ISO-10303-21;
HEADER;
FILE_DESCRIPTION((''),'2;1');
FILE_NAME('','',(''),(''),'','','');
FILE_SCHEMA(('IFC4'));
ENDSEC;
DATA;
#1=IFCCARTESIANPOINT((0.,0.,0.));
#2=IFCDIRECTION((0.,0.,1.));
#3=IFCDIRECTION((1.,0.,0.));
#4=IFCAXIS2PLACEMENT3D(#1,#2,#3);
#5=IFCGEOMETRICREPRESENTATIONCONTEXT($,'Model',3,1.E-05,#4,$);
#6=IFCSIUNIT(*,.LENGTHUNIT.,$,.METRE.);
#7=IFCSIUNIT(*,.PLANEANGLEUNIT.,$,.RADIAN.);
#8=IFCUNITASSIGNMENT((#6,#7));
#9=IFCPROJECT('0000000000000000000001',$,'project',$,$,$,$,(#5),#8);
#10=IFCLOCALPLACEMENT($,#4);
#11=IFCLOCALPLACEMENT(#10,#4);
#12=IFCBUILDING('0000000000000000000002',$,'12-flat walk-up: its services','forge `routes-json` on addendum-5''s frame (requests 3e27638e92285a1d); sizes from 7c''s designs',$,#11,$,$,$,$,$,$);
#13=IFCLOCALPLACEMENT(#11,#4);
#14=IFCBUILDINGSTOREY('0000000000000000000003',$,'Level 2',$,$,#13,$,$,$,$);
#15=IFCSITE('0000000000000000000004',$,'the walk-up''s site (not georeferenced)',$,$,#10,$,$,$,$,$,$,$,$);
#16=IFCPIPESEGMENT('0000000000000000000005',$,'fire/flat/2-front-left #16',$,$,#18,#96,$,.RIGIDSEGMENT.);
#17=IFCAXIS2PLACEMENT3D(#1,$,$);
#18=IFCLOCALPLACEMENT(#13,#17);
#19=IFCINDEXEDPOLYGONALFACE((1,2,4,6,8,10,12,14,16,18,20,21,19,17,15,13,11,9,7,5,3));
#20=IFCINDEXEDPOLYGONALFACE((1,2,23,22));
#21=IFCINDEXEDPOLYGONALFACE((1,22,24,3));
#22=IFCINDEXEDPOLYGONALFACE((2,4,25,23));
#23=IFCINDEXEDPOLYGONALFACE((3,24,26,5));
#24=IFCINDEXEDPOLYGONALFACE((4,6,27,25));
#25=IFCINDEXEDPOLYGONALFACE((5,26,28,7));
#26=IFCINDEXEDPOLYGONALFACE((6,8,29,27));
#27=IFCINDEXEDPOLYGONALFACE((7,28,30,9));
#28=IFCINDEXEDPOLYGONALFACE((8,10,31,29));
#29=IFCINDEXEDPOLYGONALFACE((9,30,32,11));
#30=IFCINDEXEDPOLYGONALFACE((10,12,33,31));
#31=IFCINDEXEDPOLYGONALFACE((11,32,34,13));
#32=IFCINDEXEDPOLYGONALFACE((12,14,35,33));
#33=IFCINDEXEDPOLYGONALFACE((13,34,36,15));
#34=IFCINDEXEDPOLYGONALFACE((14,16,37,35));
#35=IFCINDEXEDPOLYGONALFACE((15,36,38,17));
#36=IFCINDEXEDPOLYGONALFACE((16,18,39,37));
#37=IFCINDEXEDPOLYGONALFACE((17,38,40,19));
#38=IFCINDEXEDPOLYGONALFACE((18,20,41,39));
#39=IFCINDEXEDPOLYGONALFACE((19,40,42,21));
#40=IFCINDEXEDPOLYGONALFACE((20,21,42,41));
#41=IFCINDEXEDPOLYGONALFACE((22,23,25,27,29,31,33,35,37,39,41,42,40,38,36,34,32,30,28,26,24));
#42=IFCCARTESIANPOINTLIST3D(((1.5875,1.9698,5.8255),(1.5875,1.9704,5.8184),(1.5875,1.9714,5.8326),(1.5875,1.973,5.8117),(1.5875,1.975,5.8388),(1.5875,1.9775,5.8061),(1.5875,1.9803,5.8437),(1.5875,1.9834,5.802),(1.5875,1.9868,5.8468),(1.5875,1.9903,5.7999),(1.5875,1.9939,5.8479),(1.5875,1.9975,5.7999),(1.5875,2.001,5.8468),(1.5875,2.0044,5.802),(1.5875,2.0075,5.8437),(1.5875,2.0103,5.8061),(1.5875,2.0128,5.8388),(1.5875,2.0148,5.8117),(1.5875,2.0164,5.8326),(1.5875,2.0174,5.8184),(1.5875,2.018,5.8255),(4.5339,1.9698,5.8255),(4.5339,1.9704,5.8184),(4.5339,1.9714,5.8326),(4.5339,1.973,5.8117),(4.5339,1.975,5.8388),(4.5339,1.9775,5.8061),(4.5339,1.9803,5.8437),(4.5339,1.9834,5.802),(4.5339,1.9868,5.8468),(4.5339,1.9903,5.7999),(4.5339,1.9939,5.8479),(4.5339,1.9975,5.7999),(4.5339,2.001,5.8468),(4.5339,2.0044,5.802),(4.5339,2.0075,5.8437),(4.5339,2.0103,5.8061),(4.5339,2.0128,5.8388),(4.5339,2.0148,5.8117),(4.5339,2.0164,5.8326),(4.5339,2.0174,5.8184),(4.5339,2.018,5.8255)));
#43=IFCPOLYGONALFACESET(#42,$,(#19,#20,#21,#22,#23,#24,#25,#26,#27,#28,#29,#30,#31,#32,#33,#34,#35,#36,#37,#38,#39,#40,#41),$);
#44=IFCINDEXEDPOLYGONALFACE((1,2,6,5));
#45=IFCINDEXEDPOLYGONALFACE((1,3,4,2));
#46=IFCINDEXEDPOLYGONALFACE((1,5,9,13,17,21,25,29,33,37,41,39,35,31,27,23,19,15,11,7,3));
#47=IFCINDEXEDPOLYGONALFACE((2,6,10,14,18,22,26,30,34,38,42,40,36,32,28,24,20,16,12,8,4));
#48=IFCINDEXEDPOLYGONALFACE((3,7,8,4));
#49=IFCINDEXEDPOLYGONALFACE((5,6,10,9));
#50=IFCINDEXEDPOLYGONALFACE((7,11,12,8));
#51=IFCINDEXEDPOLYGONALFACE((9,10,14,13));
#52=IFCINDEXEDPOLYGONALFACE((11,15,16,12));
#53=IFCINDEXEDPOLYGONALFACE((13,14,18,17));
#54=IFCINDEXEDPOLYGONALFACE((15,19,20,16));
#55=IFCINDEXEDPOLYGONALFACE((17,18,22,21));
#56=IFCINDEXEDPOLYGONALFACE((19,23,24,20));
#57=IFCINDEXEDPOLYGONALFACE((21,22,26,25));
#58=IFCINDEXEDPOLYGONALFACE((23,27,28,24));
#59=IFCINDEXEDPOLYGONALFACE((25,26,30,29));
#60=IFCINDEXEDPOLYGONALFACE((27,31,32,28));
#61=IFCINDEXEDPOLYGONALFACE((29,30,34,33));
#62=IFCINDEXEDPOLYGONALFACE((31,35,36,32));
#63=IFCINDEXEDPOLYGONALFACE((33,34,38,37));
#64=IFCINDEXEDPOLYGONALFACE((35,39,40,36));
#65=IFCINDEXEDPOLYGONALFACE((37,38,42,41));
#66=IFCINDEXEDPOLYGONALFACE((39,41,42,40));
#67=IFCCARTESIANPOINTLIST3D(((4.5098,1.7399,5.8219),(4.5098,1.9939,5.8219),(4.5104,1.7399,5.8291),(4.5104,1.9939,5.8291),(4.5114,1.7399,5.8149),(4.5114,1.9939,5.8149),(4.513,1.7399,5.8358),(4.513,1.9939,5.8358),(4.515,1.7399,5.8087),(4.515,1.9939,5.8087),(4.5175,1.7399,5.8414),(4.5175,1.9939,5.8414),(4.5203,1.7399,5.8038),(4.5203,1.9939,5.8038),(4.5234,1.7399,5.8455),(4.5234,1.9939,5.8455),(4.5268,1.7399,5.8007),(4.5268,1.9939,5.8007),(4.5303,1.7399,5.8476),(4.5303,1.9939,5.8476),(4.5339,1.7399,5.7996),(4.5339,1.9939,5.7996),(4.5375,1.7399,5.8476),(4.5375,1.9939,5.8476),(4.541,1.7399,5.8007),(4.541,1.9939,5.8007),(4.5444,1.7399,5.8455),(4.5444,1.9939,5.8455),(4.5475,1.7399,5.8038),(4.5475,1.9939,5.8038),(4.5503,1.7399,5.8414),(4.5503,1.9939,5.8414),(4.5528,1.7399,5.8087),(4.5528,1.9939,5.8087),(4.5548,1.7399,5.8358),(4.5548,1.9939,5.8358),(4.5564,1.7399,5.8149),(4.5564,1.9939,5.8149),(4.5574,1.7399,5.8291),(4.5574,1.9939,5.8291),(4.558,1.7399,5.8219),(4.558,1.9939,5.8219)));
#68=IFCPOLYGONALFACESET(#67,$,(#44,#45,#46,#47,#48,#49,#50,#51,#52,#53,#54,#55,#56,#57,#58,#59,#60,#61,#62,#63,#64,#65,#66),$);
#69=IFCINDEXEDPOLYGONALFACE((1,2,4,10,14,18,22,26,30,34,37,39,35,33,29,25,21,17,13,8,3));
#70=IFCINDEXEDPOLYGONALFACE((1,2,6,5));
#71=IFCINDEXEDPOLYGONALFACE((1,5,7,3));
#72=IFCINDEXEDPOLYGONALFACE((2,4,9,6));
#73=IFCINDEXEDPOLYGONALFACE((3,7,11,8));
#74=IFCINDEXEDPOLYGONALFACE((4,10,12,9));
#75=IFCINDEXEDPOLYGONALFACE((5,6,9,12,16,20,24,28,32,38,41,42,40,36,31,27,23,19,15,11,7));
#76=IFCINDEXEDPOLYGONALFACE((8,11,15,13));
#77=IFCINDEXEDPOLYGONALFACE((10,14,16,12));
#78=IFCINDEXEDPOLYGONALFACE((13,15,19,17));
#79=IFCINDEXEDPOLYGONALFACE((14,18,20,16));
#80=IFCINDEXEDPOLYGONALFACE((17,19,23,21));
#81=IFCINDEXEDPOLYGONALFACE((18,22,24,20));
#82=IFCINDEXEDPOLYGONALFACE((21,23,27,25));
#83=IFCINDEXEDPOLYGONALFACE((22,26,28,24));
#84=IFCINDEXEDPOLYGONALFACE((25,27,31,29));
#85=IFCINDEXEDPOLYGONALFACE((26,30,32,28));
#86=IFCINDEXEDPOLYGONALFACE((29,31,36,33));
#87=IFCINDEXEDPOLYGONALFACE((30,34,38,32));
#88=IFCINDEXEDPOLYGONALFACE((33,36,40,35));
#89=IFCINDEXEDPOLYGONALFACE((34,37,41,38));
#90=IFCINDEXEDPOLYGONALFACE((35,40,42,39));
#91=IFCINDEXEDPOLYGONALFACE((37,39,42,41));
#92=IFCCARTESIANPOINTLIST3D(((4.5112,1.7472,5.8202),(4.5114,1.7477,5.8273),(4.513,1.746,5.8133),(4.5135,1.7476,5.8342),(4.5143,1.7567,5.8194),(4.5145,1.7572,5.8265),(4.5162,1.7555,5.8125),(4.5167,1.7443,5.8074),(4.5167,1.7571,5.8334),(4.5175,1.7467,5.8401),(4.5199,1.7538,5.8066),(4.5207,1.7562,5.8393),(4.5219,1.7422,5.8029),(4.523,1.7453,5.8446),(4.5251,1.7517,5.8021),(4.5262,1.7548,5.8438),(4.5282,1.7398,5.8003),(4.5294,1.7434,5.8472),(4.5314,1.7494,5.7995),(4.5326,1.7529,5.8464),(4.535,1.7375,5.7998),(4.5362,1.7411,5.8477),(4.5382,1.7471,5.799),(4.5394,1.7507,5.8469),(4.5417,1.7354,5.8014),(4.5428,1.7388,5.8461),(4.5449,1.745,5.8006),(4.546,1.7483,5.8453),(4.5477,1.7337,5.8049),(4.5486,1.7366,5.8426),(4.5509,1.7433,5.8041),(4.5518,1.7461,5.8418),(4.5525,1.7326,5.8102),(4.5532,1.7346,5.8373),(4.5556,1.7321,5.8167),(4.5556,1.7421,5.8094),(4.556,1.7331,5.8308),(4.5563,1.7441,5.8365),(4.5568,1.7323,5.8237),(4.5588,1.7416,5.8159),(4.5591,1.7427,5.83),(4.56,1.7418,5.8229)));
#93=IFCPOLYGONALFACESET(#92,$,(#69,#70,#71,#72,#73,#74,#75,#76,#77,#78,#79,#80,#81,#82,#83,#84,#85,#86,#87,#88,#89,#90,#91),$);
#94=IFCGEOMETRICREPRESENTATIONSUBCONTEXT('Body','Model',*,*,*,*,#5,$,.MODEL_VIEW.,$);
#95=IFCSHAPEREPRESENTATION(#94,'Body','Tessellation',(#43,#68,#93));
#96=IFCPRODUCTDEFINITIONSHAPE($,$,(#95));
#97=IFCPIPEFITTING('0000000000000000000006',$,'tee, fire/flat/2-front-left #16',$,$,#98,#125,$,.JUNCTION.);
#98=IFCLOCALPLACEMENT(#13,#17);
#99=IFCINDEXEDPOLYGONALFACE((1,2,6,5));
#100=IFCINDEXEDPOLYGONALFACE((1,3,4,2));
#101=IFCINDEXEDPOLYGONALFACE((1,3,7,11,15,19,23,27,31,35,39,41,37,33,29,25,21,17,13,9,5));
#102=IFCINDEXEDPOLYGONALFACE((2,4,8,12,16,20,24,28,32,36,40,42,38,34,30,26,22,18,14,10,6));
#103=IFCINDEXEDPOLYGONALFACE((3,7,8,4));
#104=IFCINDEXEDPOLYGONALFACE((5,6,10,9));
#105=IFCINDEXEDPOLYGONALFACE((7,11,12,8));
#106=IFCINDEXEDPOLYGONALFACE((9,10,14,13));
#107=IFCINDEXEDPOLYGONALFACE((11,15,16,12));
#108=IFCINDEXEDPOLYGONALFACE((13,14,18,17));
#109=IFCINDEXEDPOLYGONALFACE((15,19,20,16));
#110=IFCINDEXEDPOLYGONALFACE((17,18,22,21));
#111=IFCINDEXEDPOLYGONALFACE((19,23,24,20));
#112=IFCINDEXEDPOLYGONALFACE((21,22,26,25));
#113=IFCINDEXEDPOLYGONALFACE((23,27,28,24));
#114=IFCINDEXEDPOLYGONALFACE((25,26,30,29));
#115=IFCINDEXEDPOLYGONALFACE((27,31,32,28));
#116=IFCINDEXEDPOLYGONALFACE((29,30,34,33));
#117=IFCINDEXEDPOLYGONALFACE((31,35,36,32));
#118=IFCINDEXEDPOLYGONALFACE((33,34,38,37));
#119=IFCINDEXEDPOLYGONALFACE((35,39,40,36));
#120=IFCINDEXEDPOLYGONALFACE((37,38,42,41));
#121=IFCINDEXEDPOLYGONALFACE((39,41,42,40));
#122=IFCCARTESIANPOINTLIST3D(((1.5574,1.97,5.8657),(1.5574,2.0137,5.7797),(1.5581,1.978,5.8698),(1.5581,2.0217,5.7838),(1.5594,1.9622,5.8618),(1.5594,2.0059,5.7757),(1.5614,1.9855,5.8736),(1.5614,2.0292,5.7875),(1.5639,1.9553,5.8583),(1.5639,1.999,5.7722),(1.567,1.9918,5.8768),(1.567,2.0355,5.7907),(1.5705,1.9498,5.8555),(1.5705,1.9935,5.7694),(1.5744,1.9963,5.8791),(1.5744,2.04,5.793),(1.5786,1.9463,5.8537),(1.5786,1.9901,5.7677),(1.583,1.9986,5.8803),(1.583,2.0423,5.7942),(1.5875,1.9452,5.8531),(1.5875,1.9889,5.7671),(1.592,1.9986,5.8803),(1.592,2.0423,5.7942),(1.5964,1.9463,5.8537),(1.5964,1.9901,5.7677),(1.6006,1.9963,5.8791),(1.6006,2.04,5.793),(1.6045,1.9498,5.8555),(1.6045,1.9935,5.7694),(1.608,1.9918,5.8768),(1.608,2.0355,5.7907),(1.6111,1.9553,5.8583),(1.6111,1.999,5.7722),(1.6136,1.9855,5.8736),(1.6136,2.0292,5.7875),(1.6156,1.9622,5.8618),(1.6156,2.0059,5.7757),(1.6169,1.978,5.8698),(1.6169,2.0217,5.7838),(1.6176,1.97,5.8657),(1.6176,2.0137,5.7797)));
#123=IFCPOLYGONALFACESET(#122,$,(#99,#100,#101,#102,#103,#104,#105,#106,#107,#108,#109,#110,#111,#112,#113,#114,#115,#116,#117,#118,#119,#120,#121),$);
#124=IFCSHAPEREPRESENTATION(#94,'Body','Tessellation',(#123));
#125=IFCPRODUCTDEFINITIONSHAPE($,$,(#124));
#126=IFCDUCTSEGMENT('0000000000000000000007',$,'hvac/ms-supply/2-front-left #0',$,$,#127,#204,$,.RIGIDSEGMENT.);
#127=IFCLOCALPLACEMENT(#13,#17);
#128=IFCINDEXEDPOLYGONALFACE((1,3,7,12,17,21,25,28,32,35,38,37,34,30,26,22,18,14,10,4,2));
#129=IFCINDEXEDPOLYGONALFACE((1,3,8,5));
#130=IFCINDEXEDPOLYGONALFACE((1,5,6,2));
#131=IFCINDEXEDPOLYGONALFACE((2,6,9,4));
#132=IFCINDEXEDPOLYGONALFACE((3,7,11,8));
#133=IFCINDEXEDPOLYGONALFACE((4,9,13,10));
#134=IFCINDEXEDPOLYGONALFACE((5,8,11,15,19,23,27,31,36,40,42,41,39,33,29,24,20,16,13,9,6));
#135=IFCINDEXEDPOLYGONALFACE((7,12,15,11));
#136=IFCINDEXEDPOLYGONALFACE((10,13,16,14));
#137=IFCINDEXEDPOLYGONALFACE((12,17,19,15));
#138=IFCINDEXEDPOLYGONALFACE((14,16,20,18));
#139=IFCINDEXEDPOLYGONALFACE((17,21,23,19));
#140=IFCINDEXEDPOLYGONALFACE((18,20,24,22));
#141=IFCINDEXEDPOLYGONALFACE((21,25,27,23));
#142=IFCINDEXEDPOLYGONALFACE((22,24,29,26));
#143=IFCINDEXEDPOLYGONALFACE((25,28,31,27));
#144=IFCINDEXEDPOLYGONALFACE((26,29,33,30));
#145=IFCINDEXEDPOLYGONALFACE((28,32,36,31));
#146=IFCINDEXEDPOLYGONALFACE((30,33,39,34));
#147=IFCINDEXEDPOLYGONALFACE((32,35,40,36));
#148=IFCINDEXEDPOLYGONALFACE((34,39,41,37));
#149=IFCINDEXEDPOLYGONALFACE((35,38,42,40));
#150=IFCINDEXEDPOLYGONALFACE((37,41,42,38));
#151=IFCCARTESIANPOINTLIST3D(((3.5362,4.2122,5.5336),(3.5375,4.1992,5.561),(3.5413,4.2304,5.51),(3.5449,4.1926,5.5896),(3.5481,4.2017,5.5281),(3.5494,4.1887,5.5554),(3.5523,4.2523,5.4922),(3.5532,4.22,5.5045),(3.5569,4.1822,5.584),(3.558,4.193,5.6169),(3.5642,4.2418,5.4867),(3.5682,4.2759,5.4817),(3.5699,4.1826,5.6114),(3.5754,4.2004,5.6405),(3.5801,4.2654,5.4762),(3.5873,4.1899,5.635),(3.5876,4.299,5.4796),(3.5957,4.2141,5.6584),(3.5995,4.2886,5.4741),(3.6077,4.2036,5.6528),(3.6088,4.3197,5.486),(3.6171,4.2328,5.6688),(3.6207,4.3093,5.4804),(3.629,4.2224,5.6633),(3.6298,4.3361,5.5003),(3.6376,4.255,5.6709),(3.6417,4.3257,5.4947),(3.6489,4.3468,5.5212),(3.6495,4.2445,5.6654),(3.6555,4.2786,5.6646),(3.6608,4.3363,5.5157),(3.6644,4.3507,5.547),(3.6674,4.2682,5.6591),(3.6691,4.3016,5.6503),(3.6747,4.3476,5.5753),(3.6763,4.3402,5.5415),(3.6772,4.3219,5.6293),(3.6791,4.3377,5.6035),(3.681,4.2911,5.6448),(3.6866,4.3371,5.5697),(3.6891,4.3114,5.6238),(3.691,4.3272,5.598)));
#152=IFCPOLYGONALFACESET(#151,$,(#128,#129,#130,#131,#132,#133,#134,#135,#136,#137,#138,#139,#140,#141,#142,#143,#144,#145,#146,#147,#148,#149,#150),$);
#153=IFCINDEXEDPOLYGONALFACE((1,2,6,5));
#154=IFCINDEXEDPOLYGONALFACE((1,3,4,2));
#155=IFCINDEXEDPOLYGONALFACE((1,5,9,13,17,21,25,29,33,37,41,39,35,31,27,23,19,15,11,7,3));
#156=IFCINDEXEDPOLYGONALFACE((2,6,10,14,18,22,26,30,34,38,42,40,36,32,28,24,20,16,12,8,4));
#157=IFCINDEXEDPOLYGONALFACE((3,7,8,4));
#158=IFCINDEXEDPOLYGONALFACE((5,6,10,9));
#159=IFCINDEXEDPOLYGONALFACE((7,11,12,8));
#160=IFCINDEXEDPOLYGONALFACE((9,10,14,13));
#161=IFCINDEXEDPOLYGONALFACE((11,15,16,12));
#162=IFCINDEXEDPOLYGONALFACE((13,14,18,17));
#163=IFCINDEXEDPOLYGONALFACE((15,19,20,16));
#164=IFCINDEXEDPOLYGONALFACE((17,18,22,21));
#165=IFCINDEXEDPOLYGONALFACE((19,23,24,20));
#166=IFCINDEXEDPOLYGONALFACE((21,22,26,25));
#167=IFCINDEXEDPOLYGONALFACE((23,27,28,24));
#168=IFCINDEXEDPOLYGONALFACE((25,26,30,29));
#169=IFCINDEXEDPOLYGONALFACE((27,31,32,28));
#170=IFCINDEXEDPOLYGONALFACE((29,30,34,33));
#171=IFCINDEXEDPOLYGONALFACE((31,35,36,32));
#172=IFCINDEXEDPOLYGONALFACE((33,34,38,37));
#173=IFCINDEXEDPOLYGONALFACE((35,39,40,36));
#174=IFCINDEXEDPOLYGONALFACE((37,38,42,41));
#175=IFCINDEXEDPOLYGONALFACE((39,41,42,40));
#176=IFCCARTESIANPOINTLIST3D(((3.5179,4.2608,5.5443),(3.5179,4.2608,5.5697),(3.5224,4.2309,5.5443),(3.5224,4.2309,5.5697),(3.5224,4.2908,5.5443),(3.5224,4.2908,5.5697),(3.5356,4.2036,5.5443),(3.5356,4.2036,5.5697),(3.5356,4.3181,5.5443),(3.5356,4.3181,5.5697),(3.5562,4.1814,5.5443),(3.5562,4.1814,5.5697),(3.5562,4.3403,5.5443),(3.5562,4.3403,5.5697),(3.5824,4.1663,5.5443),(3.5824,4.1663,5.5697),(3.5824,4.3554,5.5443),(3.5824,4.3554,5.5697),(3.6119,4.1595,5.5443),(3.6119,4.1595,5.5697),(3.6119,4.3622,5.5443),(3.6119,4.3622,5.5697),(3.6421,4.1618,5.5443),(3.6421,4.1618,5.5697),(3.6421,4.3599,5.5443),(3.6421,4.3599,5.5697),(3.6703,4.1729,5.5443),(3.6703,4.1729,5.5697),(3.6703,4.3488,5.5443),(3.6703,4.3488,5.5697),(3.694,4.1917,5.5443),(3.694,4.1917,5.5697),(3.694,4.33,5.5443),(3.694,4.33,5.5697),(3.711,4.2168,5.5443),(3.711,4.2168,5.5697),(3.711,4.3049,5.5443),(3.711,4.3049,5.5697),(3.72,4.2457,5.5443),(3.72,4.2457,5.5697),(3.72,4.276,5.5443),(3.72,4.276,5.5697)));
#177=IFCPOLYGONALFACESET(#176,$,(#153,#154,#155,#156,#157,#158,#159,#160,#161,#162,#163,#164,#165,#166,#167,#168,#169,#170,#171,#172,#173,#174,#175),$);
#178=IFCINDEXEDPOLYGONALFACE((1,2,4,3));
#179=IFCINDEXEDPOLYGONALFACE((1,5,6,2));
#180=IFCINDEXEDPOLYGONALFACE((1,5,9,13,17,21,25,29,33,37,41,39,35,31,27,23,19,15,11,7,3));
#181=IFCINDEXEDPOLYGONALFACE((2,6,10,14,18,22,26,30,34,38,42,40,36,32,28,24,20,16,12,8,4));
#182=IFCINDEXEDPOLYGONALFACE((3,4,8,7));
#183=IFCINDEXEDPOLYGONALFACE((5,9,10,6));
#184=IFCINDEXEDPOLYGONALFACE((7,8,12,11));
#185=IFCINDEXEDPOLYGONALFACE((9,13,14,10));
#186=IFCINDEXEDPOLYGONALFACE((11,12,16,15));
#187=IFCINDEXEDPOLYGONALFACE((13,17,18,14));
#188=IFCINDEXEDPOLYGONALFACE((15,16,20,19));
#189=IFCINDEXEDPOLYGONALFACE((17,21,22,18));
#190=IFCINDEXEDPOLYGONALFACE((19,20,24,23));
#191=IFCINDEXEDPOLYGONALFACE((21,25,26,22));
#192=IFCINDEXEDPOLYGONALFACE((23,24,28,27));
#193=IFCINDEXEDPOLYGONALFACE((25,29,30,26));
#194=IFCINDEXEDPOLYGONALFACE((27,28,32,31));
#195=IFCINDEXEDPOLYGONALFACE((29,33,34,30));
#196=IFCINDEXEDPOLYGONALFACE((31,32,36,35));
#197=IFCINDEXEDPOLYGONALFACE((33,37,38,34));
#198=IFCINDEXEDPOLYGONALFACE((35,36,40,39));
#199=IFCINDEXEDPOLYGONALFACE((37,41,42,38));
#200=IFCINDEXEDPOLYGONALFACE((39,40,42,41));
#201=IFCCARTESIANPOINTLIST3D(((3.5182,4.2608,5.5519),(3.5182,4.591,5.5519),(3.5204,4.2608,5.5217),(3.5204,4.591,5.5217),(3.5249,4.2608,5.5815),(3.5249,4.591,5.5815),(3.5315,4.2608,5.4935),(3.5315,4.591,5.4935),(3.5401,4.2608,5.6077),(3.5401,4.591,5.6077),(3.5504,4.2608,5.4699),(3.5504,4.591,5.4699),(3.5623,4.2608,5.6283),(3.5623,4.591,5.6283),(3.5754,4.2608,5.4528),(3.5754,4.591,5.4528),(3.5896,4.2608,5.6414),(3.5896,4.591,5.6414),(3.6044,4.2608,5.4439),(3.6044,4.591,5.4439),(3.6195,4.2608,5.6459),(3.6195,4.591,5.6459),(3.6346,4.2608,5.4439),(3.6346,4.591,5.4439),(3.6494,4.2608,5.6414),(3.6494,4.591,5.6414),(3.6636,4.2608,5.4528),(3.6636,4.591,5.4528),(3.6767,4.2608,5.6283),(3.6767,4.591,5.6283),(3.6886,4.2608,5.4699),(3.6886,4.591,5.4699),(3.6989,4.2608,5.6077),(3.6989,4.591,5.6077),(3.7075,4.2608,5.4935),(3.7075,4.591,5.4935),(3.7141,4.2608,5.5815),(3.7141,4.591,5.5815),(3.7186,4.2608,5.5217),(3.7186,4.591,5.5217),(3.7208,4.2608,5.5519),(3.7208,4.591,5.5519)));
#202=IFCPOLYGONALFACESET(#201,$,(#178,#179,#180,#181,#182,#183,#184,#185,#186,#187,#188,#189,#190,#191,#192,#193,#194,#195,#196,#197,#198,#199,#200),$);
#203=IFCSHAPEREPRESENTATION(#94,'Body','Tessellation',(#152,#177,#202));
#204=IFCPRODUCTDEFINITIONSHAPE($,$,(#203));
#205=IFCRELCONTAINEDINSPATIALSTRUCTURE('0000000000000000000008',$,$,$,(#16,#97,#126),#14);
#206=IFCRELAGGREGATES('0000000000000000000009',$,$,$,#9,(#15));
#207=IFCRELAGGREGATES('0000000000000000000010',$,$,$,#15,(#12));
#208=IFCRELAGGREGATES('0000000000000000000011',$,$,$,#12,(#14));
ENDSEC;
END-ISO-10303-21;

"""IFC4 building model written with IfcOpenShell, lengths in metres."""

from ifc_helpers import new_model, entity, si_unit, frame, origin_with_axes, place, context, subcontext, project, spatial, element, save


model = new_model("IFC4")

# Units and contexts
model_context = context("Model", 3, precision=1e-05, world=origin_with_axes())
body_context = subcontext(model_context, "Body", "Model", "MODEL_VIEW")
ifc_project = project(units=[si_unit("LENGTHUNIT", "METRE"), si_unit("PLANEANGLEUNIT", "RADIAN")], contexts=[model_context])

# Site, building, storey
site_placement = place(None, origin_with_axes())
site = spatial("IfcSite", under=ifc_project, at=site_placement, Name="the walk-up's site (not georeferenced)")
building_placement = place(site_placement, origin_with_axes())
building = spatial("IfcBuilding", under=site, at=building_placement, Name="12-flat walk-up: its services", Description="forge `routes-json` on addendum-5's frame (requests 3e27638e92285a1d); sizes from 7c's designs")
storey_placement = place(building_placement, origin_with_axes())
storey = spatial("IfcBuildingStorey", under=building, at=storey_placement, Name="Level 2")

# Pipe segment
pipe_segment_1_placement = place(storey_placement, frame((1.5875, 1.9939, 5.8237), z_axis=(0.0, 0.0, 1.0), x_axis=(1.0, 0.0, 0.0)))
element("IfcPipeSegment", 1, at=pipe_segment_1_placement, inside=storey, Name="fire/flat/2-front-left #16", PredefinedType="RIGIDSEGMENT", context=body_context, shape_type="AdvancedSweptSolid", body=[
    entity("IfcSweptDiskSolid", entity("IfcPolyline", [entity("IfcCartesianPoint", [0.0, 0.0, 0.0]), entity("IfcCartesianPoint", [2.9464, 0.0, 0.0])]), 0.0241),
    entity("IfcSweptDiskSolid", entity("IfcPolyline", [entity("IfcCartesianPoint", [2.9464, 0.0, 0.0]), entity("IfcCartesianPoint", [2.9464, -0.254, 0.0])]), 0.0241),
    entity("IfcSweptDiskSolid", entity("IfcPolyline", [entity("IfcCartesianPoint", [2.9464, -0.254, 0.0]), entity("IfcCartesianPoint", [2.9496, -0.2445, -0.0008])]), 0.0241),
])

# Pipe fitting
pipe_fitting_1_placement = place(storey_placement, frame((1.5875, 1.972, 5.8668), z_axis=(0.0, 0.0, 1.0), x_axis=(1.0, 0.0, 0.0)))
element("IfcPipeFitting", 2, at=pipe_fitting_1_placement, inside=storey, Name="tee, fire/flat/2-front-left #16", PredefinedType="JUNCTION", context=body_context, shape_type="AdvancedSweptSolid", body=[
    entity("IfcSweptDiskSolid", entity("IfcPolyline", [entity("IfcCartesianPoint", [0.0, 0.0, 0.0]), entity("IfcCartesianPoint", [0.0, 0.0437, -0.0861])]), 0.0302),
])

# Duct segment
duct_segment_1_placement = place(storey_placement, frame((3.6076, 4.2713, 5.5753), z_axis=(0.0, 0.0, 1.0), x_axis=(1.0, 0.0, 0.0)))
element("IfcDuctSegment", 3, at=duct_segment_1_placement, inside=storey, Name="hvac/ms-supply/2-front-left #0", PredefinedType="RIGIDSEGMENT", context=body_context, shape_type="AdvancedSweptSolid", body=[
    entity("IfcSweptDiskSolid", entity("IfcPolyline", [entity("IfcCartesianPoint", [0.0, 0.0, 0.0]), entity("IfcCartesianPoint", [0.0119, -0.0105, -0.0055])]), 0.1016),
    entity("IfcSweptDiskSolid", entity("IfcPolyline", [entity("IfcCartesianPoint", [0.0119, -0.0105, -0.0055]), entity("IfcCartesianPoint", [0.0119, -0.0105, -0.0309])]), 0.1016),
    entity("IfcSweptDiskSolid", entity("IfcPolyline", [entity("IfcCartesianPoint", [0.0119, -0.0105, -0.0309]), entity("IfcCartesianPoint", [0.0119, 0.3197, -0.0309])]), 0.1016),
])

save(model, "model.ifc")
